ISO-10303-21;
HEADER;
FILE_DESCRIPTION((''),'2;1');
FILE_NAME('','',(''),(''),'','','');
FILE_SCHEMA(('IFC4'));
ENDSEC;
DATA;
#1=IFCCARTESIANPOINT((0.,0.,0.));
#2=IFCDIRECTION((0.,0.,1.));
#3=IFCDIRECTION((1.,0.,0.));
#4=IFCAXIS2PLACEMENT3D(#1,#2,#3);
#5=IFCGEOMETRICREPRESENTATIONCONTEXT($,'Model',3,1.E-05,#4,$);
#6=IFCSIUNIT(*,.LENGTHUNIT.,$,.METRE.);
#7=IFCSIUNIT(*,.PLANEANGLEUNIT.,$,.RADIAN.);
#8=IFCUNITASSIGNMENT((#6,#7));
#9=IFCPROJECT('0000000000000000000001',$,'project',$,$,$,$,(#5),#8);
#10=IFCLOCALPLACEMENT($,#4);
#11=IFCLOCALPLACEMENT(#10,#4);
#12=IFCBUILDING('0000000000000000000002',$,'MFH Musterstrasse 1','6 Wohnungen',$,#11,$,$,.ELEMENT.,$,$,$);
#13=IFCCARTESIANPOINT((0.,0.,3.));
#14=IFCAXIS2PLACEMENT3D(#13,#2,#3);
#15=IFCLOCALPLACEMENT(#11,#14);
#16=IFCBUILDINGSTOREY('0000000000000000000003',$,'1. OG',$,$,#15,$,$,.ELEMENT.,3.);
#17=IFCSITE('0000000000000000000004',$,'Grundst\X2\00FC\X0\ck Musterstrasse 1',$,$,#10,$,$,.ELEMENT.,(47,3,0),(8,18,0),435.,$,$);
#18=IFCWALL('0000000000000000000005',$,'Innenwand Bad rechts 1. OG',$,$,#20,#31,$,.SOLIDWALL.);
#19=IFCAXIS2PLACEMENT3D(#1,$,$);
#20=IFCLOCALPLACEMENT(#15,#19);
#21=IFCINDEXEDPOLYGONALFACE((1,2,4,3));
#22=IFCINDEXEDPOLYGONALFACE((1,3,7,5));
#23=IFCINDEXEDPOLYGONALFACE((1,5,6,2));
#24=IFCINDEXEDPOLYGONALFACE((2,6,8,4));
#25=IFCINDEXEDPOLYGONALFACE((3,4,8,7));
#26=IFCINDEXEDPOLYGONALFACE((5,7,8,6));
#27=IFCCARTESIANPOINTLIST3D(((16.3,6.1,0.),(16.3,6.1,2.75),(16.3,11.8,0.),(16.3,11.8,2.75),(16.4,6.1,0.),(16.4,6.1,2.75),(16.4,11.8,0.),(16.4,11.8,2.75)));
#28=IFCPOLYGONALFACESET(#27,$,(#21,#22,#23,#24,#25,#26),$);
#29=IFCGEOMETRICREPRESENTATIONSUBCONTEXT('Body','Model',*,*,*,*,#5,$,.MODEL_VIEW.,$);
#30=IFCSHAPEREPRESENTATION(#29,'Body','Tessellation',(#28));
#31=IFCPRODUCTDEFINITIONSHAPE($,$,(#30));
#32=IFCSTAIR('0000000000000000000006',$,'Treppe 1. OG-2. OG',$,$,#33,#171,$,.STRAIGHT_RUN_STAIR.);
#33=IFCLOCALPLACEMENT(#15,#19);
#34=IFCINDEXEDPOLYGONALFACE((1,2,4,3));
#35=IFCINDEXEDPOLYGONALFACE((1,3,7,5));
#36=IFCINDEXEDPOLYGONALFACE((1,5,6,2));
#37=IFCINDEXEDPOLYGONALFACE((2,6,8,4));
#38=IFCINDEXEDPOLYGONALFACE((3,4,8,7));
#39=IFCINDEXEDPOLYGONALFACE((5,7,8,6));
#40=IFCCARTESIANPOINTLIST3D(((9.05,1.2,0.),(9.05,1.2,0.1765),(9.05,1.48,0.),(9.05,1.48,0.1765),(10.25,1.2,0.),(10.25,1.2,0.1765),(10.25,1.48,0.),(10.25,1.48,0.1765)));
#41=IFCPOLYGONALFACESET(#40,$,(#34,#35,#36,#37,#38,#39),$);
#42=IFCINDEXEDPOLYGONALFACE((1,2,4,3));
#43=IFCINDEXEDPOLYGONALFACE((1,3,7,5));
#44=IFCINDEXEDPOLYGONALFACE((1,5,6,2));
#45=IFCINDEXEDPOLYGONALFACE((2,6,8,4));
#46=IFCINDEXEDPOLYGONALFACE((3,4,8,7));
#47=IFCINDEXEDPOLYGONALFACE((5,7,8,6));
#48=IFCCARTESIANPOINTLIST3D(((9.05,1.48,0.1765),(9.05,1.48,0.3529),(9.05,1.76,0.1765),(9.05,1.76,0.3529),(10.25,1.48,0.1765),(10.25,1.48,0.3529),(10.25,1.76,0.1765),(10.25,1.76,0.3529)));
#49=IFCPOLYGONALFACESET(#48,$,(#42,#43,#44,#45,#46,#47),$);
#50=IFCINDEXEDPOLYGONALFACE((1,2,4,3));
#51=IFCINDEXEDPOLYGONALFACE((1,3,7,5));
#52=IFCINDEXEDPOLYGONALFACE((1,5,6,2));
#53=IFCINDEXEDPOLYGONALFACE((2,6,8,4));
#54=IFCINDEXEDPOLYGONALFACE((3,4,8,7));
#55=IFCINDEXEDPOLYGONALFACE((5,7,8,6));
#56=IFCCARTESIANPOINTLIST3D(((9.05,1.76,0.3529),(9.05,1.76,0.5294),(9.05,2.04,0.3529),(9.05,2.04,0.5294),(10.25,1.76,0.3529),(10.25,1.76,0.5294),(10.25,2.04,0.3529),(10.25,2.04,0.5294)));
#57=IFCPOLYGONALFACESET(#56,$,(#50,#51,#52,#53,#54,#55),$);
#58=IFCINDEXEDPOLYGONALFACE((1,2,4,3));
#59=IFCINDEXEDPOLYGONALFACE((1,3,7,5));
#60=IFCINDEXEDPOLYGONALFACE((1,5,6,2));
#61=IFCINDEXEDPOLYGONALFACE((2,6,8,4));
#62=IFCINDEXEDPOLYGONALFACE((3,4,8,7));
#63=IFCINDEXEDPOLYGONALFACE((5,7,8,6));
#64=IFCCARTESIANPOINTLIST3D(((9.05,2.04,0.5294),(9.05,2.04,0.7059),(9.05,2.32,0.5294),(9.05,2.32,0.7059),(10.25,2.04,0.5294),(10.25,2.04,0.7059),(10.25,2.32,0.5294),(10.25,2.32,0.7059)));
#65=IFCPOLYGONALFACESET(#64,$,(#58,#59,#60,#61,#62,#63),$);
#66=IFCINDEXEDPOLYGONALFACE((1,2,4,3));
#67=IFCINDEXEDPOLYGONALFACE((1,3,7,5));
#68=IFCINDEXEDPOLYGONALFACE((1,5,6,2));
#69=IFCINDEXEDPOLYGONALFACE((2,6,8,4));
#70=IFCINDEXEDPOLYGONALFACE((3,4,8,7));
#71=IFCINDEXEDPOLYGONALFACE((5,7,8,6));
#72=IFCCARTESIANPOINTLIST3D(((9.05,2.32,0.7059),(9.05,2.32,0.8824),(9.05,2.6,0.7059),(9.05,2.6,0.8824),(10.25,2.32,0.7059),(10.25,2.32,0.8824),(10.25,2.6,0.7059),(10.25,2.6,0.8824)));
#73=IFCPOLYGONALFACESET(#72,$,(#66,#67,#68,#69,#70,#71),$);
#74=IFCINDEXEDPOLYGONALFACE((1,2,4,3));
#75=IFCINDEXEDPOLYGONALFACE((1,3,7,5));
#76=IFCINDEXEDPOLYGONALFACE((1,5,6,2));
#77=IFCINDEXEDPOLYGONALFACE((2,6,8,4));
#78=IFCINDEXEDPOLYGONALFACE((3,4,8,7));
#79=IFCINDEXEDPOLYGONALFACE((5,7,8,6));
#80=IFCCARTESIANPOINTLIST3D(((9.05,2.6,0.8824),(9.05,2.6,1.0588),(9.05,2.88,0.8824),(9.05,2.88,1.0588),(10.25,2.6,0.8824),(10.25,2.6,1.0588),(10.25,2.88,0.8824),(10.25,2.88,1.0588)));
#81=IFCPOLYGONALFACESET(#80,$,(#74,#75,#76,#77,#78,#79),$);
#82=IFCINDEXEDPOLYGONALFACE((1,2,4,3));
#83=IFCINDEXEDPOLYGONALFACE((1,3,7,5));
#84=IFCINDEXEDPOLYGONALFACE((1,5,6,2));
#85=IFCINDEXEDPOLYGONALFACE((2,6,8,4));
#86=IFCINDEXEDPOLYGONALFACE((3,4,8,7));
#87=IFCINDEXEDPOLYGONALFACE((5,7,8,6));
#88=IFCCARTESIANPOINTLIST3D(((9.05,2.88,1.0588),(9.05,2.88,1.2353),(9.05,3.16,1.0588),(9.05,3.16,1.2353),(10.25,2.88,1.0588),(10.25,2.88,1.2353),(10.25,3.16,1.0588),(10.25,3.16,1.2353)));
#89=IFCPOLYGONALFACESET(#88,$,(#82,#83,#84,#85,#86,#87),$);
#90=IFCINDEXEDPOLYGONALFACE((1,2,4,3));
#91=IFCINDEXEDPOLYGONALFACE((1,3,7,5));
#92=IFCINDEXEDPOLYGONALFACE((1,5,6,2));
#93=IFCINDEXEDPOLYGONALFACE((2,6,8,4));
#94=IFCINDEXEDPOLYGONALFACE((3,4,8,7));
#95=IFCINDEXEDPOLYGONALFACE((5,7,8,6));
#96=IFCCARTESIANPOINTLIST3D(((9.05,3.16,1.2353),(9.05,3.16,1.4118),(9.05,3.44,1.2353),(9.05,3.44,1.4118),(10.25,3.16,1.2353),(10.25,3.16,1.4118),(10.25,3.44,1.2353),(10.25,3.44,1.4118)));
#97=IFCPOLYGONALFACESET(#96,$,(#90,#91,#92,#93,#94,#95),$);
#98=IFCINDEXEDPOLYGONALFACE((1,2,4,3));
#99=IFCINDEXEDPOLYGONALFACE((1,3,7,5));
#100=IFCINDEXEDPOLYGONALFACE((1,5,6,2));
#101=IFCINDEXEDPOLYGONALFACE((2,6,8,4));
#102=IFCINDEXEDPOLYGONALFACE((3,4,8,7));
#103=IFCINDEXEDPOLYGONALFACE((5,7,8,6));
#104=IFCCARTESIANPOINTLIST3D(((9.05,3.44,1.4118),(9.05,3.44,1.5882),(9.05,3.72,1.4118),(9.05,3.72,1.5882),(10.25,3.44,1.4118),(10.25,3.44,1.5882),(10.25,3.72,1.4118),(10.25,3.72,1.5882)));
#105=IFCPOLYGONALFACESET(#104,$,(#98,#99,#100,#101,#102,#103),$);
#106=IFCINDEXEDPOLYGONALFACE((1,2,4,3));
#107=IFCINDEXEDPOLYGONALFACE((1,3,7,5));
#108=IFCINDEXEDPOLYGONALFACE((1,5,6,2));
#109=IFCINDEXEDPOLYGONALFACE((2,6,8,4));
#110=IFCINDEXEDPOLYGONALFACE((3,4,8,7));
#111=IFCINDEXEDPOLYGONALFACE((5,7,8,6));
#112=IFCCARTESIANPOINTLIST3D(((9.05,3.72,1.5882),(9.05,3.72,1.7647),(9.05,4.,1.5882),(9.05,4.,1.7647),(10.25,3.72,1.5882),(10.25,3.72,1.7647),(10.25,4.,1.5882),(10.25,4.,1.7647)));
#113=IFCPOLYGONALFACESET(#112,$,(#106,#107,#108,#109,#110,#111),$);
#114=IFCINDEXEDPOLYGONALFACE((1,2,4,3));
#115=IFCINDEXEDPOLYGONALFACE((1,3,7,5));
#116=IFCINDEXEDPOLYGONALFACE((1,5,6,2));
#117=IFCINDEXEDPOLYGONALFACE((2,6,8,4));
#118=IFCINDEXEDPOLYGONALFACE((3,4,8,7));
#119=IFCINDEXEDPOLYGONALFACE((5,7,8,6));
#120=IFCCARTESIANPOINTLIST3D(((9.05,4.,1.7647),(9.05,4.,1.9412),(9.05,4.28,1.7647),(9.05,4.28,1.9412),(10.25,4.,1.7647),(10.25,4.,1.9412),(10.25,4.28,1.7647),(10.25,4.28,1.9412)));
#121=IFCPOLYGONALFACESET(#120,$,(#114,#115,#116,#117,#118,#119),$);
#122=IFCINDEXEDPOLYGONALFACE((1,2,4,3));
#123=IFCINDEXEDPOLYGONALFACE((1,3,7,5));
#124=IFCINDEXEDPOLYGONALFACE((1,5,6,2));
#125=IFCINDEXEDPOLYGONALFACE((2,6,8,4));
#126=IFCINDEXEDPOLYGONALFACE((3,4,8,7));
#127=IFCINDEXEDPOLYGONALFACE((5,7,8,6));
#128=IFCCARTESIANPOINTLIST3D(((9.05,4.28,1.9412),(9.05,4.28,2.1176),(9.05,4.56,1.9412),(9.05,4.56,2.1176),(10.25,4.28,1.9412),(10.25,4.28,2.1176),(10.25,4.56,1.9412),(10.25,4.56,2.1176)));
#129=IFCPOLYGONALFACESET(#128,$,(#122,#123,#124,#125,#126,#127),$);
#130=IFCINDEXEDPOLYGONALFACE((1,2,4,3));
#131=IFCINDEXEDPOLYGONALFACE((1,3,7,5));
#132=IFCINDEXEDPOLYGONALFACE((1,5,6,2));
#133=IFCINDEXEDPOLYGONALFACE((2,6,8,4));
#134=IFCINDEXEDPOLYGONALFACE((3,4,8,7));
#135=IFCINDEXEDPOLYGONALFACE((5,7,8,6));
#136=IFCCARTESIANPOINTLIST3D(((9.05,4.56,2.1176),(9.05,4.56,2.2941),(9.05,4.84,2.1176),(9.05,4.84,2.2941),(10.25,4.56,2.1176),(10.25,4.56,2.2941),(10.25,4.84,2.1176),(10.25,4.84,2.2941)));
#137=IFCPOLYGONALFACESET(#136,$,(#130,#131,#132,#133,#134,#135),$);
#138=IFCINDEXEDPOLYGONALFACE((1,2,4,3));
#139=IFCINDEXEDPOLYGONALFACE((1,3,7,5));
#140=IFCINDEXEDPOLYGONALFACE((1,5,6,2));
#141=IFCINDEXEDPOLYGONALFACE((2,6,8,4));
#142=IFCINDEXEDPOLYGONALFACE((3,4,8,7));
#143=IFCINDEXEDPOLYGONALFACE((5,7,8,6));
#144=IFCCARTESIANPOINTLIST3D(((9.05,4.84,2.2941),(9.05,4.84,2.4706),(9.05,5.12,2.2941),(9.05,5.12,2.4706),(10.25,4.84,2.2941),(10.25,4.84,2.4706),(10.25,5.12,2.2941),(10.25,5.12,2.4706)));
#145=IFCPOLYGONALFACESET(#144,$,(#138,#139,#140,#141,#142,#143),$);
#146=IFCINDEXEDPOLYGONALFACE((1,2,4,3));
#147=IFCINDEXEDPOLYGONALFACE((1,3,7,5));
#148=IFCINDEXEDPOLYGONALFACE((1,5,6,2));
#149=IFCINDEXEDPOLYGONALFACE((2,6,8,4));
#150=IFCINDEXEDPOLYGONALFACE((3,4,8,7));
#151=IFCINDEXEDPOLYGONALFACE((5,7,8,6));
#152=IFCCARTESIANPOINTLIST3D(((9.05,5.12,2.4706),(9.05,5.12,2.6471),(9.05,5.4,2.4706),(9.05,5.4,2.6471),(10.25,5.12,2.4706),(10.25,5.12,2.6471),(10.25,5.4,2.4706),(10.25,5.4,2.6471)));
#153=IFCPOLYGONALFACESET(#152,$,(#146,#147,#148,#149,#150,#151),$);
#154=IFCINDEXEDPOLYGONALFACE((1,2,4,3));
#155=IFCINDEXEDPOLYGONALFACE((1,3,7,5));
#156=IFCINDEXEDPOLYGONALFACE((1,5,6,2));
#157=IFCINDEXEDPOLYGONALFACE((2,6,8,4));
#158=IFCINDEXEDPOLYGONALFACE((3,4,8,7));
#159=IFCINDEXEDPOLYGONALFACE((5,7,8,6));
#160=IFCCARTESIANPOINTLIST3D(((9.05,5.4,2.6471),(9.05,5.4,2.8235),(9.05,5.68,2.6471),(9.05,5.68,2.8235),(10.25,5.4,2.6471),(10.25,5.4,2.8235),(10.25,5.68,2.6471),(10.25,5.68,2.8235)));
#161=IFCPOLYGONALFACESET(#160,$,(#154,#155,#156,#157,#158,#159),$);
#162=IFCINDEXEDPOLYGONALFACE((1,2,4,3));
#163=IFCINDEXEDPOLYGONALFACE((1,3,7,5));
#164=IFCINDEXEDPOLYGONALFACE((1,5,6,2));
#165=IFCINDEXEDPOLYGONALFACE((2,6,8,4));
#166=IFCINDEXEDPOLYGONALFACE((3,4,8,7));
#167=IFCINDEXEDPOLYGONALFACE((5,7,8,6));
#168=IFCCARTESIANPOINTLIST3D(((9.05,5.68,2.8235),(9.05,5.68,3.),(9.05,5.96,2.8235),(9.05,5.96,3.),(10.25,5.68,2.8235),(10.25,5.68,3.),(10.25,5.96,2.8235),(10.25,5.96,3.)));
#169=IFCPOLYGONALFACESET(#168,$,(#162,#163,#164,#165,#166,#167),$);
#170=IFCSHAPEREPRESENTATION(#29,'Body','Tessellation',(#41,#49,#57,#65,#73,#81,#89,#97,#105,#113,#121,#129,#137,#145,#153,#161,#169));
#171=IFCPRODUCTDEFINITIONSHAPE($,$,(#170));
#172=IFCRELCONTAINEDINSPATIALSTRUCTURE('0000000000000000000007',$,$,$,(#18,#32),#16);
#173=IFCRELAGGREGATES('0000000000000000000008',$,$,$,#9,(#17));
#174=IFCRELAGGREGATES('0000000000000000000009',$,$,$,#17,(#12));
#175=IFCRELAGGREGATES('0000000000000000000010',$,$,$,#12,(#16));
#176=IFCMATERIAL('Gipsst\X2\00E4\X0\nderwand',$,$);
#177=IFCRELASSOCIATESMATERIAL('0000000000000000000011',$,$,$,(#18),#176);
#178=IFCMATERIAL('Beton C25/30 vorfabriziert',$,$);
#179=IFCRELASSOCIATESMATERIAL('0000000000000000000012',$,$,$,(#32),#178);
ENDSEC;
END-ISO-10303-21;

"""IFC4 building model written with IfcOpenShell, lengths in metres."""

from ifc_helpers import new_model, si_unit, frame, frame_2d, origin_with_axes, place, context, subcontext, project, spatial, rectangle, extrude, material, element, save


model = new_model("IFC4")

# Units and contexts
model_context = context("Model", 3, precision=1e-05, world=origin_with_axes())
body_context = subcontext(model_context, "Body", "Model", "MODEL_VIEW")
ifc_project = project(units=[si_unit("LENGTHUNIT", "METRE"), si_unit("PLANEANGLEUNIT", "RADIAN")], contexts=[model_context])

# Site, building, storey
site_placement = place(None, origin_with_axes())
site = spatial("IfcSite", under=ifc_project, at=site_placement, Name="Grundstück Musterstrasse 1", CompositionType="ELEMENT", RefLatitude=(47, 3, 0), RefLongitude=(8, 18, 0), RefElevation=435.0)
building_placement = place(site_placement, origin_with_axes())
building = spatial("IfcBuilding", under=site, at=building_placement, Name="MFH Musterstrasse 1", Description="6 Wohnungen", CompositionType="ELEMENT")
storey_placement = place(building_placement, frame((0.0, 0.0, 3.0), z_axis=(0.0, 0.0, 1.0), x_axis=(1.0, 0.0, 0.0)))
storey = spatial("IfcBuildingStorey", under=building, at=storey_placement, Name="1. OG", CompositionType="ELEMENT", Elevation=3.0)

# Shared definitions
ifc_material_1 = material(Name="Gipsständerwand")

# Wall
wall_1_placement = place(storey_placement, origin_with_axes())
element("IfcWall", 1, at=wall_1_placement, inside=storey, material=ifc_material_1, Name="Innenwand Bad rechts 1. OG", PredefinedType="SOLIDWALL", context=body_context, shape_type="SweptSolid", body=[
    extrude(rectangle(XDim=0.1, YDim=5.7, at=frame_2d((0.05, 2.85), x_axis=(1.0, 0.0))), frame((16.3, 6.1, 0.0), z_axis=(0.0, 0.0, 1.0), x_axis=(1.0, 0.0, 0.0)), (0.0, 0.0, 1.0), 2.75),
])

# Stair
ifc_material_2 = material(Name="Beton C25/30 vorfabriziert")
stair_placement = place(storey_placement, origin_with_axes())
element("IfcStair", 2, at=stair_placement, inside=storey, material=ifc_material_2, Name="Treppe 1. OG-2. OG", PredefinedType="STRAIGHT_RUN_STAIR", context=body_context, shape_type="SweptSolid", body=[
    extrude(rectangle(XDim=1.2, YDim=0.28, at=frame_2d((0.6, 0.14), x_axis=(1.0, 0.0))), frame((9.05, 1.2, 0.0), z_axis=(0.0, 0.0, 1.0), x_axis=(1.0, 0.0, 0.0)), (0.0, 0.0, 1.0), 0.1765),
    extrude(rectangle(XDim=1.2, YDim=0.28, at=frame_2d((0.6, 0.14), x_axis=(1.0, 0.0))), frame((9.05, 1.48, 0.1765), z_axis=(0.0, 0.0, 1.0), x_axis=(1.0, 0.0, 0.0)), (0.0, 0.0, 1.0), 0.1765),
    extrude(rectangle(XDim=1.2, YDim=0.28, at=frame_2d((0.6, 0.14), x_axis=(1.0, 0.0))), frame((9.05, 1.76, 0.3529), z_axis=(0.0, 0.0, 1.0), x_axis=(1.0, 0.0, 0.0)), (0.0, 0.0, 1.0), 0.1765),
    extrude(rectangle(XDim=1.2, YDim=0.28, at=frame_2d((0.6, 0.14), x_axis=(1.0, 0.0))), frame((9.05, 2.04, 0.5294), z_axis=(0.0, 0.0, 1.0), x_axis=(1.0, 0.0, 0.0)), (0.0, 0.0, 1.0), 0.1765),
    extrude(rectangle(XDim=1.2, YDim=0.28, at=frame_2d((0.6, 0.14), x_axis=(1.0, 0.0))), frame((9.05, 2.32, 0.7059), z_axis=(0.0, 0.0, 1.0), x_axis=(1.0, 0.0, 0.0)), (0.0, 0.0, 1.0), 0.1765),
    extrude(rectangle(XDim=1.2, YDim=0.28, at=frame_2d((0.6, 0.14), x_axis=(1.0, 0.0))), frame((9.05, 2.6, 0.8824), z_axis=(0.0, 0.0, 1.0), x_axis=(1.0, 0.0, 0.0)), (0.0, 0.0, 1.0), 0.1765),
    extrude(rectangle(XDim=1.2, YDim=0.28, at=frame_2d((0.6, 0.14), x_axis=(1.0, 0.0))), frame((9.05, 2.88, 1.0588), z_axis=(0.0, 0.0, 1.0), x_axis=(1.0, 0.0, 0.0)), (0.0, 0.0, 1.0), 0.1765),
    extrude(rectangle(XDim=1.2, YDim=0.28, at=frame_2d((0.6, 0.14), x_axis=(1.0, 0.0))), frame((9.05, 3.16, 1.2353), z_axis=(0.0, 0.0, 1.0), x_axis=(1.0, 0.0, 0.0)), (0.0, 0.0, 1.0), 0.1765),
    extrude(rectangle(XDim=1.2, YDim=0.28, at=frame_2d((0.6, 0.14), x_axis=(1.0, 0.0))), frame((9.05, 3.44, 1.4118), z_axis=(0.0, 0.0, 1.0), x_axis=(1.0, 0.0, 0.0)), (0.0, 0.0, 1.0), 0.1765),
    extrude(rectangle(XDim=1.2, YDim=0.28, at=frame_2d((0.6, 0.14), x_axis=(1.0, 0.0))), frame((9.05, 3.72, 1.5882), z_axis=(0.0, 0.0, 1.0), x_axis=(1.0, 0.0, 0.0)), (0.0, 0.0, 1.0), 0.1765),
    extrude(rectangle(XDim=1.2, YDim=0.28, at=frame_2d((0.6, 0.14), x_axis=(1.0, 0.0))), frame((9.05, 4.0, 1.7647), z_axis=(0.0, 0.0, 1.0), x_axis=(1.0, 0.0, 0.0)), (0.0, 0.0, 1.0), 0.1765),
    extrude(rectangle(XDim=1.2, YDim=0.28, at=frame_2d((0.6, 0.14), x_axis=(1.0, 0.0))), frame((9.05, 4.28, 1.9412), z_axis=(0.0, 0.0, 1.0), x_axis=(1.0, 0.0, 0.0)), (0.0, 0.0, 1.0), 0.1765),
    extrude(rectangle(XDim=1.2, YDim=0.28, at=frame_2d((0.6, 0.14), x_axis=(1.0, 0.0))), frame((9.05, 4.56, 2.1176), z_axis=(0.0, 0.0, 1.0), x_axis=(1.0, 0.0, 0.0)), (0.0, 0.0, 1.0), 0.1765),
    extrude(rectangle(XDim=1.2, YDim=0.28, at=frame_2d((0.6, 0.14), x_axis=(1.0, 0.0))), frame((9.05, 4.84, 2.2941), z_axis=(0.0, 0.0, 1.0), x_axis=(1.0, 0.0, 0.0)), (0.0, 0.0, 1.0), 0.1765),
    extrude(rectangle(XDim=1.2, YDim=0.28, at=frame_2d((0.6, 0.14), x_axis=(1.0, 0.0))), frame((9.05, 5.12, 2.4706), z_axis=(0.0, 0.0, 1.0), x_axis=(1.0, 0.0, 0.0)), (0.0, 0.0, 1.0), 0.1765),
    extrude(rectangle(XDim=1.2, YDim=0.28, at=frame_2d((0.6, 0.14), x_axis=(1.0, 0.0))), frame((9.05, 5.4, 2.6471), z_axis=(0.0, 0.0, 1.0), x_axis=(1.0, 0.0, 0.0)), (0.0, 0.0, 1.0), 0.1765),
    extrude(rectangle(XDim=1.2, YDim=0.28, at=frame_2d((0.6, 0.14), x_axis=(1.0, 0.0))), frame((9.05, 5.68, 2.8235), z_axis=(0.0, 0.0, 1.0), x_axis=(1.0, 0.0, 0.0)), (0.0, 0.0, 1.0), 0.1765),
])

save(model, "model.ifc")
